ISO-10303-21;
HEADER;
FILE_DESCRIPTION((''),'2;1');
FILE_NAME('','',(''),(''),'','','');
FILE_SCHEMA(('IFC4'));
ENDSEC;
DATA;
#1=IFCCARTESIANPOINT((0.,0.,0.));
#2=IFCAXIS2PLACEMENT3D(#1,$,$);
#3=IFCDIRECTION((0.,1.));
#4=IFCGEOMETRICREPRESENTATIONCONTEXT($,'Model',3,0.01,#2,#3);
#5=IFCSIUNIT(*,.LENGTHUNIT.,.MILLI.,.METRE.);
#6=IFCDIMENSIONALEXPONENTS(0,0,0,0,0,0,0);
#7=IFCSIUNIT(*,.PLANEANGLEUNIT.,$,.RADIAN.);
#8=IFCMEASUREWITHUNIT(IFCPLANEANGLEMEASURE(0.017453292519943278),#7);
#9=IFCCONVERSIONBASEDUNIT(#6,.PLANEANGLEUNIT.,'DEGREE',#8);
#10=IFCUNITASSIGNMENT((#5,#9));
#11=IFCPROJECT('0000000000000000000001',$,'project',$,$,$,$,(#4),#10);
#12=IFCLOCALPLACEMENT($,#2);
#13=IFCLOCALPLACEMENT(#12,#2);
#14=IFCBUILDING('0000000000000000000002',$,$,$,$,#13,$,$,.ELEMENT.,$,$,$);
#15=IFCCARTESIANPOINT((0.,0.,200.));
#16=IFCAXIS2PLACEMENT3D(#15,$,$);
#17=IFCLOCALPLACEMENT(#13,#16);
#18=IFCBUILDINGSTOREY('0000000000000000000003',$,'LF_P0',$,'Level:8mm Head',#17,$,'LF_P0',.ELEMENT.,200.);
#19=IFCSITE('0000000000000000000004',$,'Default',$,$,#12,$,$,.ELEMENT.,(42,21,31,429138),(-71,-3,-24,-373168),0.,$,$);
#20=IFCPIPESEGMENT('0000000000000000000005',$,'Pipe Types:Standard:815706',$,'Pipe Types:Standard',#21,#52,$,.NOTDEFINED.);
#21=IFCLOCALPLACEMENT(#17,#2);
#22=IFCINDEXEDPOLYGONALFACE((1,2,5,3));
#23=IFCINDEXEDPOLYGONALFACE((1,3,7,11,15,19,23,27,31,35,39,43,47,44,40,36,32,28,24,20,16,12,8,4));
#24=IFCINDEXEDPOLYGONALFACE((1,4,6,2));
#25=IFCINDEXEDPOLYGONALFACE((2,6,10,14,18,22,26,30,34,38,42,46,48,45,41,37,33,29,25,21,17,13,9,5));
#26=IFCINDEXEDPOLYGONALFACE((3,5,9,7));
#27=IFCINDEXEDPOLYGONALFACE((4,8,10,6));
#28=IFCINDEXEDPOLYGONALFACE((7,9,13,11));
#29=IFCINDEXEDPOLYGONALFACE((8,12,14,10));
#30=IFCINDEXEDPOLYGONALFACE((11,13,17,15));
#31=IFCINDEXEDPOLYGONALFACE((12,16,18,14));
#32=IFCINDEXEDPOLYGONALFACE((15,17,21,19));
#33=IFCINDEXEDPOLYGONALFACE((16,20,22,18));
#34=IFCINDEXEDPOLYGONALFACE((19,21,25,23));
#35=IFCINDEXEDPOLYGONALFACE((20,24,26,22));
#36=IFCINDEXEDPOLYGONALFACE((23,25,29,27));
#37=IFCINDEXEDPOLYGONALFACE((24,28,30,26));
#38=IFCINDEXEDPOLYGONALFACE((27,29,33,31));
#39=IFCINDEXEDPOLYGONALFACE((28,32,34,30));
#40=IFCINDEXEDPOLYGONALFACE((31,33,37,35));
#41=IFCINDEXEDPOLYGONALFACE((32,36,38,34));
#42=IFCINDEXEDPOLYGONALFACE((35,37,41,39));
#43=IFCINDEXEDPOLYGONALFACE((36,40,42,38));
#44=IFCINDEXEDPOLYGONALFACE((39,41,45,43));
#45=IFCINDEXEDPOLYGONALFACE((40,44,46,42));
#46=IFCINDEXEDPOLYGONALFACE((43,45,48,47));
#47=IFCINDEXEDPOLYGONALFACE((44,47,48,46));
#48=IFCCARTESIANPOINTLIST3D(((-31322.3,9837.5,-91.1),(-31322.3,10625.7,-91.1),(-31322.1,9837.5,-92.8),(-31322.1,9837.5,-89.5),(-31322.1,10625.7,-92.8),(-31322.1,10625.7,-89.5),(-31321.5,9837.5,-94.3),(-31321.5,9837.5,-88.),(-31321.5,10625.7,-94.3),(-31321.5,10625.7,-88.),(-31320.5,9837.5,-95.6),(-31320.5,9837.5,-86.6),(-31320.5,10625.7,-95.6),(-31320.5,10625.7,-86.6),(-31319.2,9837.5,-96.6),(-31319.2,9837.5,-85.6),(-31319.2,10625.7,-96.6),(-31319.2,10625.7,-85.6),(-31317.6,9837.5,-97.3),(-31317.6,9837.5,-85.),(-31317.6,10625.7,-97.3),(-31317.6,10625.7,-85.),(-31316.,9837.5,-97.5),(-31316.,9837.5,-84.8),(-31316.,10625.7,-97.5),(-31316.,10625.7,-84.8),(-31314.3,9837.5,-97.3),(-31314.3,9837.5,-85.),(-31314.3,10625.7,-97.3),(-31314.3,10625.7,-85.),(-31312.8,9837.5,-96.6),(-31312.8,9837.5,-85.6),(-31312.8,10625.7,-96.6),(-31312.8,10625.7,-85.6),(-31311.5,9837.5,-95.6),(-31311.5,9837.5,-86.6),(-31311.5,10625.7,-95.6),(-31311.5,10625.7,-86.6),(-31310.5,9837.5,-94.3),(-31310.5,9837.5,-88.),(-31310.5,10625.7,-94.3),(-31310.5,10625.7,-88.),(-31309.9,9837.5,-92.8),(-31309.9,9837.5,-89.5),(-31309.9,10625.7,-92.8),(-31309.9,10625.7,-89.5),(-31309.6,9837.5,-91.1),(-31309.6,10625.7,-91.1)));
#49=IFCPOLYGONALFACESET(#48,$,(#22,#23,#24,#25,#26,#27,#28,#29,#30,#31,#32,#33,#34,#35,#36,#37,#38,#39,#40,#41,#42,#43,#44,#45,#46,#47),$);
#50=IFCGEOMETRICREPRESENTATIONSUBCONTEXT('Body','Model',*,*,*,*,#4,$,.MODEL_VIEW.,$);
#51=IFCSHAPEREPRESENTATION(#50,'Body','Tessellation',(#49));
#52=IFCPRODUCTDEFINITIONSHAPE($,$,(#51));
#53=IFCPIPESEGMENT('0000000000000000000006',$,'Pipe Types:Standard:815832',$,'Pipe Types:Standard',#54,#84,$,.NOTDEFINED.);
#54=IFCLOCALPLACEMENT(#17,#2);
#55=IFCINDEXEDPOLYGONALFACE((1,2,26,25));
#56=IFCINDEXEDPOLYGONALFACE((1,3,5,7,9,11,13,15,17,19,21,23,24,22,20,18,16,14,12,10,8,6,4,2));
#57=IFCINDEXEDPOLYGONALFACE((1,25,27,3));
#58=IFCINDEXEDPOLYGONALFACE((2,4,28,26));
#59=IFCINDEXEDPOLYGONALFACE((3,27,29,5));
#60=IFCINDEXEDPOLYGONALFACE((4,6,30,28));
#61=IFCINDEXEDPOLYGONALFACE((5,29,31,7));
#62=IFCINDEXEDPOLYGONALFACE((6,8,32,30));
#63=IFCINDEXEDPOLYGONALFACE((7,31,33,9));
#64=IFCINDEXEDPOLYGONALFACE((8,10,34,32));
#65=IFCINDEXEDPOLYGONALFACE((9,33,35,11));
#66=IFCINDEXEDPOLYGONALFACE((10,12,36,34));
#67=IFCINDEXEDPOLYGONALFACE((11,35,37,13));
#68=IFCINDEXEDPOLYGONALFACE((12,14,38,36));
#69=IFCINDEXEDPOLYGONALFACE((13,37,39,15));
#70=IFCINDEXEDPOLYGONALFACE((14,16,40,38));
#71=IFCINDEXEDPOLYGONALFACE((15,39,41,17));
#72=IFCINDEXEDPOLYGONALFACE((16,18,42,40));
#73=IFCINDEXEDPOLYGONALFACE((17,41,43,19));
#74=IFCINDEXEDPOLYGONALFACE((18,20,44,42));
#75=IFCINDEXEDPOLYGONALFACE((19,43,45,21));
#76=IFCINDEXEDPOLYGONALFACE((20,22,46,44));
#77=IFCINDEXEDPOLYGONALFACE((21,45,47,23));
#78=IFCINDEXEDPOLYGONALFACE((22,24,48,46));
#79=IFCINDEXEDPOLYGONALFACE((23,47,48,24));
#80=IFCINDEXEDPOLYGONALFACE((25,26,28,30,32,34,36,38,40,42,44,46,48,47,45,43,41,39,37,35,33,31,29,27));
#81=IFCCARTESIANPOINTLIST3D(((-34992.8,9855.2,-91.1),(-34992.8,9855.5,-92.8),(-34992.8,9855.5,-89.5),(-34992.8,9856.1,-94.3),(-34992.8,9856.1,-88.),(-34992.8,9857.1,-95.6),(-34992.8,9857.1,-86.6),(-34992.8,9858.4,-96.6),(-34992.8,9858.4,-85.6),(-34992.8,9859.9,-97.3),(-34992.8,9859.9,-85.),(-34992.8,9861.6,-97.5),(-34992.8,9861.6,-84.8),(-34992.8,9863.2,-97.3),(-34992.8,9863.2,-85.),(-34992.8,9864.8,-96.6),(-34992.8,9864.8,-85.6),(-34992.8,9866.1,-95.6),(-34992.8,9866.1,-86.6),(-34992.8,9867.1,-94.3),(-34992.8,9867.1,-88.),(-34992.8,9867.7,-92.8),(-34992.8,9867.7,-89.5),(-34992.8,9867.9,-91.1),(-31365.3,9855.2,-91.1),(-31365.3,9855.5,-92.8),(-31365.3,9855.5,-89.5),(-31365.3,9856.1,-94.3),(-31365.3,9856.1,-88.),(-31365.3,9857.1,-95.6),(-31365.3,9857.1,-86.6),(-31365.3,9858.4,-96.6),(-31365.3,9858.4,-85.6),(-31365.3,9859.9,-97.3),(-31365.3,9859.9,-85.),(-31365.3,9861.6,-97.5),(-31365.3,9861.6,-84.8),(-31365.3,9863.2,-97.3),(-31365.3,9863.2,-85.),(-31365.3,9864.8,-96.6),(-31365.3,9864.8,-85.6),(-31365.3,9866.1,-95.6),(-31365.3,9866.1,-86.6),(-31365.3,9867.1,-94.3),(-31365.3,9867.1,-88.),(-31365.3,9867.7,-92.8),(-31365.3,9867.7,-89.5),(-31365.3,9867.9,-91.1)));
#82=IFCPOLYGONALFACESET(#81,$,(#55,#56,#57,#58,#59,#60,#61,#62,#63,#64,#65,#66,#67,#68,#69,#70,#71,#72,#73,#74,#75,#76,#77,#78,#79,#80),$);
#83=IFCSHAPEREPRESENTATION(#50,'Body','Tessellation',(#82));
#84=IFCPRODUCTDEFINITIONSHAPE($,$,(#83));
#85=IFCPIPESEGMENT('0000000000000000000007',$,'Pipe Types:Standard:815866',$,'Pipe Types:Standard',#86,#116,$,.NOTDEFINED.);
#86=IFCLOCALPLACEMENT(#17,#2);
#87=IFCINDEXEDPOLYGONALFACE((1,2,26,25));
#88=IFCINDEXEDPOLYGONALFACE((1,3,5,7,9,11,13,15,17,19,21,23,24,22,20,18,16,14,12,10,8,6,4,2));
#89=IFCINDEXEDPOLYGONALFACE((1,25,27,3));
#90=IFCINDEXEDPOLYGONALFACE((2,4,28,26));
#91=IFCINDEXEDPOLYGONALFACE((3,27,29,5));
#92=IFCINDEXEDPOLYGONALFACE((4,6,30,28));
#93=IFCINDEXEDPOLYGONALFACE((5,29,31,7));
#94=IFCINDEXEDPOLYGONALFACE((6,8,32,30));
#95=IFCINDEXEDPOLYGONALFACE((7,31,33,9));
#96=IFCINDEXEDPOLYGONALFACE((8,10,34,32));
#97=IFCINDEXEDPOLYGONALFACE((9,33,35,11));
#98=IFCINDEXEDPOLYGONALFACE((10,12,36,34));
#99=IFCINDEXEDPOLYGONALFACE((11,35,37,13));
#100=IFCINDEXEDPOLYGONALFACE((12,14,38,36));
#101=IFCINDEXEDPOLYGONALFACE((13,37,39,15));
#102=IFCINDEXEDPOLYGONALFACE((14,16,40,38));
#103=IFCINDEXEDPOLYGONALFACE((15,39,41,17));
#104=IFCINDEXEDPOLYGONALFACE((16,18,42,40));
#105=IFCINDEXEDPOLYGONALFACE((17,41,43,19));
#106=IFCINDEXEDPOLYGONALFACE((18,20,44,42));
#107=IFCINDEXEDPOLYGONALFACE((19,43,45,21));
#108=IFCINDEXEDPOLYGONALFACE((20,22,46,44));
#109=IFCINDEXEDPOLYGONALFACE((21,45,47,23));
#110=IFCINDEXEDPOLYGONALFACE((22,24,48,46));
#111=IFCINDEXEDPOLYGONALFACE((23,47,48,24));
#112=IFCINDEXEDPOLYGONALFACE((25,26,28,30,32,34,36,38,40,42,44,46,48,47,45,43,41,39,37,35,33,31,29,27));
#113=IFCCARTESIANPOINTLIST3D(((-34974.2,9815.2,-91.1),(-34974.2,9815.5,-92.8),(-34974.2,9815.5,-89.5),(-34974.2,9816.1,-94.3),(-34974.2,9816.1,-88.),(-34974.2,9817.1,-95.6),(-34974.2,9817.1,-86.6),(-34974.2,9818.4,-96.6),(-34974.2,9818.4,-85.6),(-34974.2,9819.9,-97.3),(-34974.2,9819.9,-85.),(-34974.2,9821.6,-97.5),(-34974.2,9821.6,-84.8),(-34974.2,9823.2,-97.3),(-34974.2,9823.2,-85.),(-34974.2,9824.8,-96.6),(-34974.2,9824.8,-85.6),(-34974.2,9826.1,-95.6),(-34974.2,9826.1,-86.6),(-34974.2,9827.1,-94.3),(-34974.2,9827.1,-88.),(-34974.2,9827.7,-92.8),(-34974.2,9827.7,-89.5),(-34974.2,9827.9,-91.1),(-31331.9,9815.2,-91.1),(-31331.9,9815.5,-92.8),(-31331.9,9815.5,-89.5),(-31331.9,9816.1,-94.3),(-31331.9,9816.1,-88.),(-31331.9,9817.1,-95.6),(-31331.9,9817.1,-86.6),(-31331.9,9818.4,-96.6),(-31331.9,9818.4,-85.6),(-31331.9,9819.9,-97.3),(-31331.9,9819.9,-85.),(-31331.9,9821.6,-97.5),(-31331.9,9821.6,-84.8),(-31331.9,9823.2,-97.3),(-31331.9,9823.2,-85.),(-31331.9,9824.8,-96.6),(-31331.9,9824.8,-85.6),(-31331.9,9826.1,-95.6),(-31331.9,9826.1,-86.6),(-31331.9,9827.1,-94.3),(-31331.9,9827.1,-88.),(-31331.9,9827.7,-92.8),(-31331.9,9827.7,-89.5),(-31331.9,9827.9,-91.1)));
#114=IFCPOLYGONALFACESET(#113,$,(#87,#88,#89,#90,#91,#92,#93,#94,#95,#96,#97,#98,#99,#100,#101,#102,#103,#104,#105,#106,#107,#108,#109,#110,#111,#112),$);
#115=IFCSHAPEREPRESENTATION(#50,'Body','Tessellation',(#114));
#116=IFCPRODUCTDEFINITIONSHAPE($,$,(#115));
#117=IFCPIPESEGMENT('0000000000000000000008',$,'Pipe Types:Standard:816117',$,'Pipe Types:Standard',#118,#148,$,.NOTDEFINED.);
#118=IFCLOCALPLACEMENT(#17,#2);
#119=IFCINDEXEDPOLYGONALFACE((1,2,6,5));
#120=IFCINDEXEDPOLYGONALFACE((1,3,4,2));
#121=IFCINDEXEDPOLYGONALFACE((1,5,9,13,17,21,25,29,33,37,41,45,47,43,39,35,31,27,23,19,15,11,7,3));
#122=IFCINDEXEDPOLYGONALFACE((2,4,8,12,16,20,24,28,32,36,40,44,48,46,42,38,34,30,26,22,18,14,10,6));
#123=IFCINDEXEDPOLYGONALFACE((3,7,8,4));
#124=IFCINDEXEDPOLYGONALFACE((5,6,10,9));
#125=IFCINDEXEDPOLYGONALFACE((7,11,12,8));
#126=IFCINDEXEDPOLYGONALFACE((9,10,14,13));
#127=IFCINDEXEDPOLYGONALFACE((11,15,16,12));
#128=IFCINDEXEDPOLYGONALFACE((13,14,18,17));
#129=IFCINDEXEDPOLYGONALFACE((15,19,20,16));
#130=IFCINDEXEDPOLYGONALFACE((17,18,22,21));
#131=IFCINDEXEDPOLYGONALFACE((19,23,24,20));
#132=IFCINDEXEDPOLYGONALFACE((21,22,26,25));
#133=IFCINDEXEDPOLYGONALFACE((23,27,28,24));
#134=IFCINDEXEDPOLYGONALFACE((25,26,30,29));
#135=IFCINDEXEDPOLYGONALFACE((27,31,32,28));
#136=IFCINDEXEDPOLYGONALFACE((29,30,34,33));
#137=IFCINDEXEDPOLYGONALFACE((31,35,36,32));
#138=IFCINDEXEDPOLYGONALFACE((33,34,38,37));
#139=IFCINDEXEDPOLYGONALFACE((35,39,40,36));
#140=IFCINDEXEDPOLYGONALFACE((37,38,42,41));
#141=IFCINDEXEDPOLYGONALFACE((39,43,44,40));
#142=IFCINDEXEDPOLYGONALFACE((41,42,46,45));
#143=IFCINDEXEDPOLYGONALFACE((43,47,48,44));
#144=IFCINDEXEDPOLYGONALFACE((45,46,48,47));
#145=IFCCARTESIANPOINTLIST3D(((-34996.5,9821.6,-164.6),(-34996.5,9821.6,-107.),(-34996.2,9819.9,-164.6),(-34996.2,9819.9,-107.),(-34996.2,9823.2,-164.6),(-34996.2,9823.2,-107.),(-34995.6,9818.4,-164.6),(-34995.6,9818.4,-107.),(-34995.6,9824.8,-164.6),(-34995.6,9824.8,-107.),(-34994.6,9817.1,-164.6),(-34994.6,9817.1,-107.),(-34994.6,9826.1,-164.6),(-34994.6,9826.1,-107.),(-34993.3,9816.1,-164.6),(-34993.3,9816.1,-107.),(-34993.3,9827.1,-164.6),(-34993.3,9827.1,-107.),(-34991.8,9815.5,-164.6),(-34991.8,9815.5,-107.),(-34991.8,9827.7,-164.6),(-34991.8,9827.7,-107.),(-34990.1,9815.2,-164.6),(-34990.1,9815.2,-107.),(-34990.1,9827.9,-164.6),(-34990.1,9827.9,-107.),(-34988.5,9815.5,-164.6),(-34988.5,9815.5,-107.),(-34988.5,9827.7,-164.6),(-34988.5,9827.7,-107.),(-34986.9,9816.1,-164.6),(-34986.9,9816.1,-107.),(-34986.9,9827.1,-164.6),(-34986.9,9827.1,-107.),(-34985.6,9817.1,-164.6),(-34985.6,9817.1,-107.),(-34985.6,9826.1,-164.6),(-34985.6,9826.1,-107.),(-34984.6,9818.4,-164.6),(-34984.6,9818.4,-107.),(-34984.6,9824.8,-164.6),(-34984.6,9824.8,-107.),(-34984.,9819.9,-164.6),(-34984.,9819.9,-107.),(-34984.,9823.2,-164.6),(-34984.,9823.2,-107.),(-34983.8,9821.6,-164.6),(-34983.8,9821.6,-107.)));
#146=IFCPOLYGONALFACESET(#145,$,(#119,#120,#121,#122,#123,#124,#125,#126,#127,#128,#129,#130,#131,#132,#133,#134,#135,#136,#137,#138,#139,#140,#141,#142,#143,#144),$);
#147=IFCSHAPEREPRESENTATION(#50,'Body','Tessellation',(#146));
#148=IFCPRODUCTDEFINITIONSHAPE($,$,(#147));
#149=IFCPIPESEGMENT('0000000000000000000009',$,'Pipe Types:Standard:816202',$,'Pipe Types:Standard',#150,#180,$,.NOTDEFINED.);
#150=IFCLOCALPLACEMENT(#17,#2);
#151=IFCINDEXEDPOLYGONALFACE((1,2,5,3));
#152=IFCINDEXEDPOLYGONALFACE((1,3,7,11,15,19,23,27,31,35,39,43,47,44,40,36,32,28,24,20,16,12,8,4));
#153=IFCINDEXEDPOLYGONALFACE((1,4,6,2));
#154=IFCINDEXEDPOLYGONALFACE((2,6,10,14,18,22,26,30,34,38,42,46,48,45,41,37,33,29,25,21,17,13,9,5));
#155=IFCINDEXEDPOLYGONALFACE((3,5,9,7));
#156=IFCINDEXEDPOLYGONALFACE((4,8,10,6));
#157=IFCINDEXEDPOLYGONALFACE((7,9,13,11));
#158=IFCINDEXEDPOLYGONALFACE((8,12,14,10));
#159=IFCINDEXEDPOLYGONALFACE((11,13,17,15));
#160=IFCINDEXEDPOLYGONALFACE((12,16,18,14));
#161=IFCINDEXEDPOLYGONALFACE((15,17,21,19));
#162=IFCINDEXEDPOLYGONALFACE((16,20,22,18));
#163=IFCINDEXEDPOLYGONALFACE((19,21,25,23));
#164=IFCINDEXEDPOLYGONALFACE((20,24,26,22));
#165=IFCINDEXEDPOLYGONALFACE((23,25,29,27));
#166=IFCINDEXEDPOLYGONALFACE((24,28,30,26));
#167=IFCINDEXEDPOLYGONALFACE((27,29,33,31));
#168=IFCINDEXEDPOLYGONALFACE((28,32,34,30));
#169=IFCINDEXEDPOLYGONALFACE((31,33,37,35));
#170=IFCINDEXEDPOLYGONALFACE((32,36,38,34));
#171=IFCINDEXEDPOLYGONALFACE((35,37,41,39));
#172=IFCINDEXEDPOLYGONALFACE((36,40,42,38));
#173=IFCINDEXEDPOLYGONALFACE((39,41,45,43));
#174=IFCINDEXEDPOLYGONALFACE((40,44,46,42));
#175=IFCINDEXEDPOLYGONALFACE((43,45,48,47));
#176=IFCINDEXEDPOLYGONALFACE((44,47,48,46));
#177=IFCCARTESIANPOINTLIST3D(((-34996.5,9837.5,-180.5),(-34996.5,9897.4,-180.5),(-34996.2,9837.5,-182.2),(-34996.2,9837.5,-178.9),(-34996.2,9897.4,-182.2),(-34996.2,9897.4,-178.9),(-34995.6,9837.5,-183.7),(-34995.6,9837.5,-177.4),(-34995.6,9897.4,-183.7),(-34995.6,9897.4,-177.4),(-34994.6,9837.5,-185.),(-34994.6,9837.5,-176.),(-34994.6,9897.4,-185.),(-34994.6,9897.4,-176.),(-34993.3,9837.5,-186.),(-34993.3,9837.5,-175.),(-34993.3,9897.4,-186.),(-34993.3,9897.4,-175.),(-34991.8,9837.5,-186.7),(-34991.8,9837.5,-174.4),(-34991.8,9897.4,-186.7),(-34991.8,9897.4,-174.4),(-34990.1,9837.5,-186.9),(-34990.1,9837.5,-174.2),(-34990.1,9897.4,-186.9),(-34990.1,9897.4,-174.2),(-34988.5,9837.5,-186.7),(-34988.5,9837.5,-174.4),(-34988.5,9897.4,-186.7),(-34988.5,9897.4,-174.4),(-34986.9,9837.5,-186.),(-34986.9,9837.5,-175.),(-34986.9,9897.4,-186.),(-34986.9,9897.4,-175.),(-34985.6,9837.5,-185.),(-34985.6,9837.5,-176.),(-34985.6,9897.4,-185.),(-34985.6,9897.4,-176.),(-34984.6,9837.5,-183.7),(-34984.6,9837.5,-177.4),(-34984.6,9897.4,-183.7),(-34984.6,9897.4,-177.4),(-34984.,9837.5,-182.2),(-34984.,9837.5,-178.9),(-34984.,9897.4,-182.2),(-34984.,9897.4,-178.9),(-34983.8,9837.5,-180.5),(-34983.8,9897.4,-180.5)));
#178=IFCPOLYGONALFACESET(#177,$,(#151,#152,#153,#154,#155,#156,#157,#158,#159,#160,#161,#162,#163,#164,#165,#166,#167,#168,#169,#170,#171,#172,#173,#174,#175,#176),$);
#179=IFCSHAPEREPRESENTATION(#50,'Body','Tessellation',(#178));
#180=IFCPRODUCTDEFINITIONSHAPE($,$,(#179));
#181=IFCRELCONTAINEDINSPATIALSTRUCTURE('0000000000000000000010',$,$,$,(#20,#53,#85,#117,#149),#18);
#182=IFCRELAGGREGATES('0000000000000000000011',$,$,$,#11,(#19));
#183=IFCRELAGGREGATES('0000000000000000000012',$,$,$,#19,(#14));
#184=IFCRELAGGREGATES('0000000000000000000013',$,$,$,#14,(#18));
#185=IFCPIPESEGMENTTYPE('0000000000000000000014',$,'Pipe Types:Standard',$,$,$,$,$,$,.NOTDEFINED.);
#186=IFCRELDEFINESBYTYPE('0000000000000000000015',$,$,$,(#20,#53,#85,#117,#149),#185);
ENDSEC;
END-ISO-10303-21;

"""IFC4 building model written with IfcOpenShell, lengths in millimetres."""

from ifc_helpers import new_model, entity, si_unit, converted_unit, direction, frame, origin, place, context, subcontext, project, spatial, arc, indexed_curve, outline, extrude, type_object, element, save


model = new_model("IFC4")

# Units and contexts
model_context = context("Model", 3, precision=0.01, world=origin(), true_north=direction((0.0, 1.0)))
body_context = subcontext(model_context, "Body", "Model", "MODEL_VIEW")
ifc_project = project(units=[si_unit("LENGTHUNIT", "METRE", prefix="MILLI"), converted_unit("PLANEANGLEUNIT", "DEGREE", entity("IfcPlaneAngleMeasure", 0.017453292519943278), si_unit("PLANEANGLEUNIT", "RADIAN"), dimensions=[0, 0, 0, 0, 0, 0, 0])], contexts=[model_context])

# Site, building, storey
site_placement = place(None, origin())
site = spatial("IfcSite", under=ifc_project, at=site_placement, Name="Default", CompositionType="ELEMENT", RefLatitude=(42, 21, 31, 429138), RefLongitude=(-71, -3, -24, -373168), RefElevation=0.0)
building_placement = place(site_placement, origin())
building = spatial("IfcBuilding", under=site, at=building_placement, CompositionType="ELEMENT")
storey_placement = place(building_placement, frame((0.0, 0.0, 200.0)))
storey = spatial("IfcBuildingStorey", under=building, at=storey_placement, Name="LF_P0", ObjectType="Level:8mm Head", LongName="LF_P0", CompositionType="ELEMENT", Elevation=200.0)

# Pipe segments
pipe_segment_type = type_object("IfcPipeSegmentType", Name="Pipe Types:Standard", PredefinedType="NOTDEFINED")
pipe_segment_1_placement = place(storey_placement, origin())
element("IfcPipeSegment", 1, at=pipe_segment_1_placement, inside=storey, type_object=pipe_segment_type, Name="Pipe Types:Standard:815706", ObjectType="Pipe Types:Standard", PredefinedType="NOTDEFINED", context=body_context, shape_type="SweptSolid", body=[
    extrude(outline(indexed_curve([(6.3, 0.0), (4.5, 4.5), (0.0, 6.3), (-4.5, 4.5), (-6.3, 0.0), (-4.5, -4.5), (0.0, -6.4), (4.5, -4.5)], segments=[arc(1, 2, 3), arc(3, 4, 5), arc(5, 6, 7), arc(7, 8, 1)], self_intersect=False)), frame((-31316.0, 9837.5, -91.1), z_axis=(0.0, 1.0, 0.0), x_axis=(-1.0, 0.0, 0.0)), (0.0, 0.0, 1.0), 788.2),
])
pipe_segment_2_placement = place(storey_placement, origin())
element("IfcPipeSegment", 2, at=pipe_segment_2_placement, inside=storey, type_object=pipe_segment_type, Name="Pipe Types:Standard:815832", ObjectType="Pipe Types:Standard", PredefinedType="NOTDEFINED", context=body_context, shape_type="SweptSolid", body=[
    extrude(outline(indexed_curve([(6.3, 0.0), (4.5, 4.5), (0.0, 6.3), (-4.5, 4.5), (-6.4, 0.0), (-4.5, -4.5), (0.0, -6.3), (4.5, -4.5)], segments=[arc(1, 2, 3), arc(3, 4, 5), arc(5, 6, 7), arc(7, 8, 1)], self_intersect=False)), frame((-34992.8, 9861.6, -91.1), z_axis=(1.0, 0.0, 0.0), x_axis=(0.0, 1.0, 0.0)), (0.0, 0.0, 1.0), 3627.5),
])
pipe_segment_3_placement = place(storey_placement, origin())
element("IfcPipeSegment", 3, at=pipe_segment_3_placement, inside=storey, type_object=pipe_segment_type, Name="Pipe Types:Standard:815866", ObjectType="Pipe Types:Standard", PredefinedType="NOTDEFINED", context=body_context, shape_type="SweptSolid", body=[
    extrude(outline(indexed_curve([(6.3, 0.0), (4.5, 4.5), (0.0, 6.3), (-4.5, 4.5), (-6.4, 0.0), (-4.5, -4.5), (0.0, -6.3), (4.5, -4.5)], segments=[arc(1, 2, 3), arc(3, 4, 5), arc(5, 6, 7), arc(7, 8, 1)], self_intersect=False)), frame((-34974.2, 9821.6, -91.1), z_axis=(1.0, 0.0, 0.0), x_axis=(0.0, 1.0, 0.0)), (0.0, 0.0, 1.0), 3642.3),
])
pipe_segment_4_placement = place(storey_placement, origin())
element("IfcPipeSegment", 4, at=pipe_segment_4_placement, inside=storey, type_object=pipe_segment_type, Name="Pipe Types:Standard:816117", ObjectType="Pipe Types:Standard", PredefinedType="NOTDEFINED", context=body_context, shape_type="SweptSolid", body=[
    extrude(outline(indexed_curve([(6.3, 0.0), (4.5, 4.5), (0.0, 6.4), (-4.5, 4.5), (-6.3, 0.0), (-4.5, -4.5), (0.0, -6.4), (4.5, -4.5)], segments=[arc(1, 2, 3), arc(3, 4, 5), arc(5, 6, 7), arc(7, 8, 1)], self_intersect=False)), frame((-34990.1, 9821.6, -164.6)), (0.0, 0.0, 1.0), 57.6),
])
pipe_segment_5_placement = place(storey_placement, origin())
element("IfcPipeSegment", 5, at=pipe_segment_5_placement, inside=storey, type_object=pipe_segment_type, Name="Pipe Types:Standard:816202", ObjectType="Pipe Types:Standard", PredefinedType="NOTDEFINED", context=body_context, shape_type="SweptSolid", body=[
    extrude(outline(indexed_curve([(6.3, 0.0), (4.5, 4.5), (0.0, 6.3), (-4.5, 4.5), (-6.3, 0.0), (-4.5, -4.5), (0.0, -6.4), (4.5, -4.5)], segments=[arc(1, 2, 3), arc(3, 4, 5), arc(5, 6, 7), arc(7, 8, 1)], self_intersect=False)), frame((-34990.1, 9837.5, -180.5), z_axis=(0.0, 1.0, 0.0), x_axis=(1.0, 0.0, 0.0)), (0.0, 0.0, 1.0), 59.9),
])

save(model, "model.ifc")
